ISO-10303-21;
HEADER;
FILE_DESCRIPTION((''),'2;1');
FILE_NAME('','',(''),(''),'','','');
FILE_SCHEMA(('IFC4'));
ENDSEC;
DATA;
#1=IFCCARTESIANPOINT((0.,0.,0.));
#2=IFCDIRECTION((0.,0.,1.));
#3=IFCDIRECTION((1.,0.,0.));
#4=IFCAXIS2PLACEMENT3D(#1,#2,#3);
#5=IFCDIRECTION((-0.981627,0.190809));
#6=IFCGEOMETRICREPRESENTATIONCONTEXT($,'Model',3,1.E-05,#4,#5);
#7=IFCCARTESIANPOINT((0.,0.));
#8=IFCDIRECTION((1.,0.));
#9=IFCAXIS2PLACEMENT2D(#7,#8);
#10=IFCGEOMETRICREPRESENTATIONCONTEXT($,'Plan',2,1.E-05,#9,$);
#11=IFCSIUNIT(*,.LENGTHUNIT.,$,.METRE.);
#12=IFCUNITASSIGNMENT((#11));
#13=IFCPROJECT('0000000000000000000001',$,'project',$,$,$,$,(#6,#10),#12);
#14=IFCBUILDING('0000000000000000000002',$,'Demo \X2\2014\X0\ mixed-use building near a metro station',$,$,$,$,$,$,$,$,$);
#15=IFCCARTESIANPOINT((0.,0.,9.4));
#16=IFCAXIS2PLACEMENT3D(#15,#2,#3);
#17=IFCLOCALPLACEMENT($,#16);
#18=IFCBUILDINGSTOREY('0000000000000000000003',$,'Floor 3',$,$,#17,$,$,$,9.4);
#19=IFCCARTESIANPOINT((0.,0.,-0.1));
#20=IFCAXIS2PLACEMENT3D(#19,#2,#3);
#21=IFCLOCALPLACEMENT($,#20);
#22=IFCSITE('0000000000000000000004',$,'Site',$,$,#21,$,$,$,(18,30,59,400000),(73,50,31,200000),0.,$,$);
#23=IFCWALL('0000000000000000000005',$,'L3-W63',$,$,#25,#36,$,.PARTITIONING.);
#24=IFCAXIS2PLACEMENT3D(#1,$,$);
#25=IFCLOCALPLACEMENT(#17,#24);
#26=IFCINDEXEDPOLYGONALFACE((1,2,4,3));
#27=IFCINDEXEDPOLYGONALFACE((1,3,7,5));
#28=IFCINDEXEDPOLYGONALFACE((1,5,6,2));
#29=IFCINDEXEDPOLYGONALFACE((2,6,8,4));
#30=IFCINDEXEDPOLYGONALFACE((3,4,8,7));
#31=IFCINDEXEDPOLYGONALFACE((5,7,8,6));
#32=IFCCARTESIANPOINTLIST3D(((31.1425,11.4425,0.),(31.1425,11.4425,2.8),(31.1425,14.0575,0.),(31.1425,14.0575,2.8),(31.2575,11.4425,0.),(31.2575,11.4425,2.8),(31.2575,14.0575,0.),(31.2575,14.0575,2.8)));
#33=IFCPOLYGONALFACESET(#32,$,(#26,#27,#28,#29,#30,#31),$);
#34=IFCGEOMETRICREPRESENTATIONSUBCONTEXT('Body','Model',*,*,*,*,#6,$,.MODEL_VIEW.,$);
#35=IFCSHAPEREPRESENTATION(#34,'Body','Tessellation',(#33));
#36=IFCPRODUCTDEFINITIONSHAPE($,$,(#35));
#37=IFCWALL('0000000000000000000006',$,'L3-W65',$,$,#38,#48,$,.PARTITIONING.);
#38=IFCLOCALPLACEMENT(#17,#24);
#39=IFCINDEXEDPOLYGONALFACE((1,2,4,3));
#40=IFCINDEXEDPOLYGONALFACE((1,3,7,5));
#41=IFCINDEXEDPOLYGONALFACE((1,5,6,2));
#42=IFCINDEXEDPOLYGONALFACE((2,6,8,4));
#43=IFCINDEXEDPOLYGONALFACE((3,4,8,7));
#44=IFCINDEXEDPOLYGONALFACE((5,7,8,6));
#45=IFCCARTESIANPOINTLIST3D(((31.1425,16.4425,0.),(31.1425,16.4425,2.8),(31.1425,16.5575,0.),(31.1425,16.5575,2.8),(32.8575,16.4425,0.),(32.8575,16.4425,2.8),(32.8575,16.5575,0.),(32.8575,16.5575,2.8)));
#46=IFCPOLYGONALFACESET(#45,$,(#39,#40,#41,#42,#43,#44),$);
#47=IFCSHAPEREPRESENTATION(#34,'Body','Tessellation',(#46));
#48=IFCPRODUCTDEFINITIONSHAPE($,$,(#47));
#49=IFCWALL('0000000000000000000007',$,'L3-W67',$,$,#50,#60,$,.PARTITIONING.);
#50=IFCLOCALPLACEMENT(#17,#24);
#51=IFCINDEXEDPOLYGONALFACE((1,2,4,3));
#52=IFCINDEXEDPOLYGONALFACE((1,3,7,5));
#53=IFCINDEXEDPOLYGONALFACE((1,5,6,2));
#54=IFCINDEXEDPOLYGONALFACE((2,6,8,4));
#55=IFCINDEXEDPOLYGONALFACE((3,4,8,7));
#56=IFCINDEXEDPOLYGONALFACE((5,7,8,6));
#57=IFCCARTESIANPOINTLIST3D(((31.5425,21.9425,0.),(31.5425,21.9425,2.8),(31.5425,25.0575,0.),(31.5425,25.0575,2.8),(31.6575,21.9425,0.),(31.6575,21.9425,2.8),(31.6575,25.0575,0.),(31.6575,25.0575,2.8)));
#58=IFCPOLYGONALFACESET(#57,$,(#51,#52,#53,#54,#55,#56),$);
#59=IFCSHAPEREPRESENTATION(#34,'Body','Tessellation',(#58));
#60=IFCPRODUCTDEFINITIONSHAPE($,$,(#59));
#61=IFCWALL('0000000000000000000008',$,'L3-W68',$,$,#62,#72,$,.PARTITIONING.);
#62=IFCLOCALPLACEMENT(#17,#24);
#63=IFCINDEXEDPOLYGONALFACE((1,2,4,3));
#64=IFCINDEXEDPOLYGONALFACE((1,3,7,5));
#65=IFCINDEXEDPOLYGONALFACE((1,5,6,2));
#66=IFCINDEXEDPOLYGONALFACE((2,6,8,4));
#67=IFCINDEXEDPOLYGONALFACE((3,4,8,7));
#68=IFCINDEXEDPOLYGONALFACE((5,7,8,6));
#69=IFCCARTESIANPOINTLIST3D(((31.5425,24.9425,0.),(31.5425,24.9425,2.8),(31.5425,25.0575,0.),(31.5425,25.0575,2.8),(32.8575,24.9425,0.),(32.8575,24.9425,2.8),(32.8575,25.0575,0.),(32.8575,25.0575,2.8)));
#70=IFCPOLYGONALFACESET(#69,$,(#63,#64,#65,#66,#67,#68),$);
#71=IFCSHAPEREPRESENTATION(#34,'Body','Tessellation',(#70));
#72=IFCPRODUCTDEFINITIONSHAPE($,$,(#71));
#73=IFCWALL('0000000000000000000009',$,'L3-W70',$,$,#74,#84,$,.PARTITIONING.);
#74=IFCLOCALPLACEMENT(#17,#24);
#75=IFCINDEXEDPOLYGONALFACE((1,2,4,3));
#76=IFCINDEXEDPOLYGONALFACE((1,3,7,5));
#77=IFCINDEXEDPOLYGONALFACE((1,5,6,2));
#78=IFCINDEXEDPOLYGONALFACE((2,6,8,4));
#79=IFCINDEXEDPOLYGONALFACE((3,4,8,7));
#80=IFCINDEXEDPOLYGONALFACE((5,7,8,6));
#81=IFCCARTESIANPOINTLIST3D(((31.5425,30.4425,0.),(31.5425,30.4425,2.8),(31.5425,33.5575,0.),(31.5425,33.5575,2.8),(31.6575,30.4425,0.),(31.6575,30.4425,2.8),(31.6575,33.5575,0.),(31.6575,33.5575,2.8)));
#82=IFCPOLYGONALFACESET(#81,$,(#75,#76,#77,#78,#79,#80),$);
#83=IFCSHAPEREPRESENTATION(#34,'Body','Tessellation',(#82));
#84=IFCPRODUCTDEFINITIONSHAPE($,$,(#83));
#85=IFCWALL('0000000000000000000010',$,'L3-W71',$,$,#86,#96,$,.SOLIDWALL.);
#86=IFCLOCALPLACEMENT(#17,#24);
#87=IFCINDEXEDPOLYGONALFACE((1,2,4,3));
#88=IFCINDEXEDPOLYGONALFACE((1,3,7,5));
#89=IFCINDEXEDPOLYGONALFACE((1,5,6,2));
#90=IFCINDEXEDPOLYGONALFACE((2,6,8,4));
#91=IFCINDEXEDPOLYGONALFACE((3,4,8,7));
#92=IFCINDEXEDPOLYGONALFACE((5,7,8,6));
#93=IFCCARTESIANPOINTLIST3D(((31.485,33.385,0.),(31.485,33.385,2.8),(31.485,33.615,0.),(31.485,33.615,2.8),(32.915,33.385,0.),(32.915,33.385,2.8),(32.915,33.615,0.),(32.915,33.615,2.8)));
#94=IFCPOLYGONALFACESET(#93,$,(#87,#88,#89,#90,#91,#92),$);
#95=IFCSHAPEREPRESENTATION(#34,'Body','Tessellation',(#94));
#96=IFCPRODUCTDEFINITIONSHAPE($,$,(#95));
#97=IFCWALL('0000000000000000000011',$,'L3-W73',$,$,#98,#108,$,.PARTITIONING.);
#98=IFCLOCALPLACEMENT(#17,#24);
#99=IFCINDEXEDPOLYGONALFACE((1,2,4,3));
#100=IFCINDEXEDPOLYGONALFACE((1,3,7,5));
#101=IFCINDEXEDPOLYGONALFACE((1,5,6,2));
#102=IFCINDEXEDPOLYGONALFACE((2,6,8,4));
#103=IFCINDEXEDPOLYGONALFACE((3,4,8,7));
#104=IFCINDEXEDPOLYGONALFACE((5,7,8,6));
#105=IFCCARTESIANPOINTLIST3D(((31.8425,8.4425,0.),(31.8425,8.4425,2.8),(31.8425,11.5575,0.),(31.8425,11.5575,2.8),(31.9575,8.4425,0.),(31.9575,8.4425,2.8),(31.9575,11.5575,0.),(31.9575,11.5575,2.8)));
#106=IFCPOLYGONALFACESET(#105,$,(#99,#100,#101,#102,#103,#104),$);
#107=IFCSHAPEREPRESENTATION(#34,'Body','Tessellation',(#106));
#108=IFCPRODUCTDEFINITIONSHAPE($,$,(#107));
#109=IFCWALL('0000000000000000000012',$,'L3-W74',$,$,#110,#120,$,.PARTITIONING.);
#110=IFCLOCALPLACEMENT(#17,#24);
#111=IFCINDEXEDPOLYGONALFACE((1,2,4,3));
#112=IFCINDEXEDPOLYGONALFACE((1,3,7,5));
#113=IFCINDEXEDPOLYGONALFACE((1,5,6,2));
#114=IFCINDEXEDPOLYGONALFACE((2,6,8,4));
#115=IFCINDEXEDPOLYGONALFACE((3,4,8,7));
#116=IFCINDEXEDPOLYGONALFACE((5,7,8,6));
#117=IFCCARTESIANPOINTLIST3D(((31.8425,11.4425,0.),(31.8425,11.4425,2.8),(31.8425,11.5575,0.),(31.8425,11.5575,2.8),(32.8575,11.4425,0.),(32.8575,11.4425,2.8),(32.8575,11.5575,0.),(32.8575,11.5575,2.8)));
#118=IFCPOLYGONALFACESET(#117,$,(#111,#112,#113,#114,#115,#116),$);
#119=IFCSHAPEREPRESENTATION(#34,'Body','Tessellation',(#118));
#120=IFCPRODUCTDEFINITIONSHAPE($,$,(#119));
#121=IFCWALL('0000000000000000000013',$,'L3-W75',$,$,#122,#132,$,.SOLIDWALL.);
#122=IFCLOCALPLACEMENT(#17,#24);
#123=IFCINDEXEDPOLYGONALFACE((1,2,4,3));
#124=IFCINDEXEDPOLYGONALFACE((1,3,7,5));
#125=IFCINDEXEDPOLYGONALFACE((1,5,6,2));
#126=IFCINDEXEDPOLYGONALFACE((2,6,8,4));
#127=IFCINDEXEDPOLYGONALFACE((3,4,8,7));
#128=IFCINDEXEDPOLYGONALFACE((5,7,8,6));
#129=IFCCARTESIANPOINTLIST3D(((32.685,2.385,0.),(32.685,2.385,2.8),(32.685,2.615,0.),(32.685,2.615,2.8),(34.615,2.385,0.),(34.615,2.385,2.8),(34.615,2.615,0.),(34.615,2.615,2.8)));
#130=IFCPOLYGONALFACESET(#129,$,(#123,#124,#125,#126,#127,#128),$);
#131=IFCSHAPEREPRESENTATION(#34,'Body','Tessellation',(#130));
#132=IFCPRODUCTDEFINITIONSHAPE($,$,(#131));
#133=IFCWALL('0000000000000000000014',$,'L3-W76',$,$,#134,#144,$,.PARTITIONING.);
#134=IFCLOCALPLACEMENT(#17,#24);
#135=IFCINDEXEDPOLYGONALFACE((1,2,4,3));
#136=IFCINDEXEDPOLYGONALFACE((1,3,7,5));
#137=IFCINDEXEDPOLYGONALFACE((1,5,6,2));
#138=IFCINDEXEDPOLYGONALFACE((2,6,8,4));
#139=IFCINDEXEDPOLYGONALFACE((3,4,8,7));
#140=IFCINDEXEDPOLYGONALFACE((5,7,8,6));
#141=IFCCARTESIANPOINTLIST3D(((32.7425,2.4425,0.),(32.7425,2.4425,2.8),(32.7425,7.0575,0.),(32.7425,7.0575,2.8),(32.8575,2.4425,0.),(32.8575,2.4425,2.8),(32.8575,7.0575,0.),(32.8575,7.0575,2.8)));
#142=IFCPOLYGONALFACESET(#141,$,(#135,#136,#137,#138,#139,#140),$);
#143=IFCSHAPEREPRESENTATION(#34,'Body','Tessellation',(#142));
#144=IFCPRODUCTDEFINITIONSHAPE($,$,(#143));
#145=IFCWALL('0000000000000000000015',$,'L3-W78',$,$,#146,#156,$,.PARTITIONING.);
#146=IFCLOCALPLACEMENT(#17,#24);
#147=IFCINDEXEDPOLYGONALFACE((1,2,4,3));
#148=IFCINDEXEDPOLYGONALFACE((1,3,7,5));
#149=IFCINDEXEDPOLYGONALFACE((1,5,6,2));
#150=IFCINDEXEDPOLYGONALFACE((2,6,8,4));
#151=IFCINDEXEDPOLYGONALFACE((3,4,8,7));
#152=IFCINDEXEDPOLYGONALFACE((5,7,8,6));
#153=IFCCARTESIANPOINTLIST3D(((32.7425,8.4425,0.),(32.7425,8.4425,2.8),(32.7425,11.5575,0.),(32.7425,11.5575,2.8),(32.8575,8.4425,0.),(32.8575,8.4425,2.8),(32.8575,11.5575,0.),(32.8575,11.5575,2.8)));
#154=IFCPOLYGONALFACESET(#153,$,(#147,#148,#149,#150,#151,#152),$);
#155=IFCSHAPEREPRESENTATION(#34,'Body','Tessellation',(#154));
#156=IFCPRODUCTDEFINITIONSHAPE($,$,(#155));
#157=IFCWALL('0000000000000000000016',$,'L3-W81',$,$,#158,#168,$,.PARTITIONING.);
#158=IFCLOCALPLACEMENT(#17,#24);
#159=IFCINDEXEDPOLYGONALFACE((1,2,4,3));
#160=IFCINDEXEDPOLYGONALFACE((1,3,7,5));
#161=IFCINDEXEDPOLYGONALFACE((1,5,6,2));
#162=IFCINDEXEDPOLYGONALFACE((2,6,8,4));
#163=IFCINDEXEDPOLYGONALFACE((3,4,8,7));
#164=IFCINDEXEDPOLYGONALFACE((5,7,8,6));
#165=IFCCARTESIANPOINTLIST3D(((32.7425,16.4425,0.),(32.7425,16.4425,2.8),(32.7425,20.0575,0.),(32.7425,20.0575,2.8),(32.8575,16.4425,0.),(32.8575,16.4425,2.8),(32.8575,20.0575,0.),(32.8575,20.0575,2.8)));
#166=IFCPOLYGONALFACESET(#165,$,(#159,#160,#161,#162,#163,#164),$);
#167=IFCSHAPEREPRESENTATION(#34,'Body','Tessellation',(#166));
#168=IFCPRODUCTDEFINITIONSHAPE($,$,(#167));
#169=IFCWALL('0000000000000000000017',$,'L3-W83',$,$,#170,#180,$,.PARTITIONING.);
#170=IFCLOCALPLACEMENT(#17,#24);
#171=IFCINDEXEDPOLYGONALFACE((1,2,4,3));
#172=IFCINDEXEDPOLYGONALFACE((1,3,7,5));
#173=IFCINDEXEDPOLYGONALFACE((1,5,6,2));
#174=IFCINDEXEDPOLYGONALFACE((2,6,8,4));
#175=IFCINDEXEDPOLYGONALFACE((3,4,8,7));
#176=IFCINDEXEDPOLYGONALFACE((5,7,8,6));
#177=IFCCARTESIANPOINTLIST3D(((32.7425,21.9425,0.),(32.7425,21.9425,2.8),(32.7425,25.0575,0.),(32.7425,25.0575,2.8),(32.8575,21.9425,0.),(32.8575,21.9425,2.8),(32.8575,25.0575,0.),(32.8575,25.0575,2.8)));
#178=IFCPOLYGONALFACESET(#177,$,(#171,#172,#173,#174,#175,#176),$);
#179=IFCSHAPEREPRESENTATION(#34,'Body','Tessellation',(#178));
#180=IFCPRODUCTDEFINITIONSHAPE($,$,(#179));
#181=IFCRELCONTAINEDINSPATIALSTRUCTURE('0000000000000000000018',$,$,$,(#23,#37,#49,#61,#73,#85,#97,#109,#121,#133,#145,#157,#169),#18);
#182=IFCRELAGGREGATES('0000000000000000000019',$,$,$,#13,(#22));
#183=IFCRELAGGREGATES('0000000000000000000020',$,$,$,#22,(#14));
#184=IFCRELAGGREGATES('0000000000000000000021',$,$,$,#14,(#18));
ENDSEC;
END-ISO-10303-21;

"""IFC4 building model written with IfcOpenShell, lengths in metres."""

from ifc_helpers import new_model, si_unit, direction, frame, origin_with_axes, origin_2d_with_axis, place, context, subcontext, project, spatial, line, indexed_curve, outline, extrude, element, save


model = new_model("IFC4")

# Units and contexts
model_context = context("Model", 3, precision=1e-05, world=origin_with_axes(), true_north=direction((-0.981627, 0.190809)))
plan_context = context("Plan", 2, precision=1e-05, world=origin_2d_with_axis())
body_context = subcontext(model_context, "Body", "Model", "MODEL_VIEW")
ifc_project = project(units=[si_unit("LENGTHUNIT", "METRE")], contexts=[model_context, plan_context])

# Site, building, storey
site_placement = place(None, frame((0.0, 0.0, -0.1), z_axis=(0.0, 0.0, 1.0), x_axis=(1.0, 0.0, 0.0)))
site = spatial("IfcSite", under=ifc_project, at=site_placement, Name="Site", RefLatitude=(18, 30, 59, 400000), RefLongitude=(73, 50, 31, 200000), RefElevation=0.0)
building = spatial("IfcBuilding", under=site, Name="Demo — mixed-use building near a metro station")
storey_placement = place(None, frame((0.0, 0.0, 9.4), z_axis=(0.0, 0.0, 1.0), x_axis=(1.0, 0.0, 0.0)))
storey = spatial("IfcBuildingStorey", under=building, at=storey_placement, Name="Floor 3", Elevation=9.4)

# Wall
wall_1_placement = place(storey_placement, frame((0.0, 0.0, -9.4), z_axis=(0.0, 0.0, 1.0), x_axis=(1.0, 0.0, 0.0)))
element("IfcWall", 1, at=wall_1_placement, inside=storey, Name="L3-W63", PredefinedType="PARTITIONING", context=body_context, shape_type="SweptSolid", body=[
    extrude(outline(indexed_curve([(31.1425, 11.4425), (31.1425, 14.0575), (31.2575, 14.0575), (31.2575, 11.4425)], segments=[line(1, 2, 3, 4, 1)])), frame((0.0, 0.0, 9.4), z_axis=(0.0, 0.0, 1.0), x_axis=(1.0, 0.0, 0.0)), (0.0, 0.0, 1.0), 2.8),
])

# Wall
wall_2_placement = place(storey_placement, frame((0.0, 0.0, -9.4), z_axis=(0.0, 0.0, 1.0), x_axis=(1.0, 0.0, 0.0)))
element("IfcWall", 2, at=wall_2_placement, inside=storey, Name="L3-W65", PredefinedType="PARTITIONING", context=body_context, shape_type="SweptSolid", body=[
    extrude(outline(indexed_curve([(32.8575, 16.4425), (31.1425, 16.4425), (31.1425, 16.5575), (32.8575, 16.5575)], segments=[line(1, 2, 3, 4, 1)])), frame((0.0, 0.0, 9.4), z_axis=(0.0, 0.0, 1.0), x_axis=(1.0, 0.0, 0.0)), (0.0, 0.0, 1.0), 2.8),
])

# Walls
wall_3_placement = place(storey_placement, frame((0.0, 0.0, -9.4), z_axis=(0.0, 0.0, 1.0), x_axis=(1.0, 0.0, 0.0)))
element("IfcWall", 3, at=wall_3_placement, inside=storey, Name="L3-W67", PredefinedType="PARTITIONING", context=body_context, shape_type="SweptSolid", body=[
    extrude(outline(indexed_curve([(31.5425, 21.9425), (31.5425, 25.0575), (31.6575, 25.0575), (31.6575, 21.9425)], segments=[line(1, 2, 3, 4, 1)])), frame((0.0, 0.0, 9.4), z_axis=(0.0, 0.0, 1.0), x_axis=(1.0, 0.0, 0.0)), (0.0, 0.0, 1.0), 2.8),
])
wall_4_placement = place(storey_placement, frame((0.0, 0.0, -9.4), z_axis=(0.0, 0.0, 1.0), x_axis=(1.0, 0.0, 0.0)))
element("IfcWall", 4, at=wall_4_placement, inside=storey, Name="L3-W68", PredefinedType="PARTITIONING", context=body_context, shape_type="SweptSolid", body=[
    extrude(outline(indexed_curve([(32.8575, 24.9425), (31.5425, 24.9425), (31.5425, 25.0575), (32.8575, 25.0575)], segments=[line(1, 2, 3, 4, 1)])), frame((0.0, 0.0, 9.4), z_axis=(0.0, 0.0, 1.0), x_axis=(1.0, 0.0, 0.0)), (0.0, 0.0, 1.0), 2.8),
])

# Walls
wall_5_placement = place(storey_placement, frame((0.0, 0.0, -9.4), z_axis=(0.0, 0.0, 1.0), x_axis=(1.0, 0.0, 0.0)))
element("IfcWall", 5, at=wall_5_placement, inside=storey, Name="L3-W70", PredefinedType="PARTITIONING", context=body_context, shape_type="SweptSolid", body=[
    extrude(outline(indexed_curve([(31.5425, 30.4425), (31.5425, 33.5575), (31.6575, 33.5575), (31.6575, 30.4425)], segments=[line(1, 2, 3, 4, 1)])), frame((0.0, 0.0, 9.4), z_axis=(0.0, 0.0, 1.0), x_axis=(1.0, 0.0, 0.0)), (0.0, 0.0, 1.0), 2.8),
])
wall_6_placement = place(storey_placement, frame((0.0, 0.0, -9.4), z_axis=(0.0, 0.0, 1.0), x_axis=(1.0, 0.0, 0.0)))
element("IfcWall", 6, at=wall_6_placement, inside=storey, Name="L3-W71", PredefinedType="SOLIDWALL", context=body_context, shape_type="SweptSolid", body=[
    extrude(outline(indexed_curve([(32.915, 33.385), (31.485, 33.385), (31.485, 33.615), (32.915, 33.615)], segments=[line(1, 2, 3, 4, 1)])), frame((0.0, 0.0, 9.4), z_axis=(0.0, 0.0, 1.0), x_axis=(1.0, 0.0, 0.0)), (0.0, 0.0, 1.0), 2.8),
])

# Walls
wall_7_placement = place(storey_placement, frame((0.0, 0.0, -9.4), z_axis=(0.0, 0.0, 1.0), x_axis=(1.0, 0.0, 0.0)))
element("IfcWall", 7, at=wall_7_placement, inside=storey, Name="L3-W73", PredefinedType="PARTITIONING", context=body_context, shape_type="SweptSolid", body=[
    extrude(outline(indexed_curve([(31.8425, 8.4425), (31.8425, 11.5575), (31.9575, 11.5575), (31.9575, 8.4425)], segments=[line(1, 2, 3, 4, 1)])), frame((0.0, 0.0, 9.4), z_axis=(0.0, 0.0, 1.0), x_axis=(1.0, 0.0, 0.0)), (0.0, 0.0, 1.0), 2.8),
])
wall_8_placement = place(storey_placement, frame((0.0, 0.0, -9.4), z_axis=(0.0, 0.0, 1.0), x_axis=(1.0, 0.0, 0.0)))
element("IfcWall", 8, at=wall_8_placement, inside=storey, Name="L3-W74", PredefinedType="PARTITIONING", context=body_context, shape_type="SweptSolid", body=[
    extrude(outline(indexed_curve([(31.8425, 11.5575), (32.8575, 11.5575), (32.8575, 11.4425), (31.8425, 11.4425)], segments=[line(1, 2, 3, 4, 1)])), frame((0.0, 0.0, 9.4), z_axis=(0.0, 0.0, 1.0), x_axis=(1.0, 0.0, 0.0)), (0.0, 0.0, 1.0), 2.8),
])
wall_9_placement = place(storey_placement, frame((0.0, 0.0, -9.4), z_axis=(0.0, 0.0, 1.0), x_axis=(1.0, 0.0, 0.0)))
element("IfcWall", 9, at=wall_9_placement, inside=storey, Name="L3-W75", PredefinedType="SOLIDWALL", context=body_context, shape_type="SweptSolid", body=[
    extrude(outline(indexed_curve([(32.685, 2.615), (34.615, 2.615), (34.615, 2.385), (32.685, 2.385)], segments=[line(1, 2, 3, 4, 1)])), frame((0.0, 0.0, 9.4), z_axis=(0.0, 0.0, 1.0), x_axis=(1.0, 0.0, 0.0)), (0.0, 0.0, 1.0), 2.8),
])
wall_10_placement = place(storey_placement, frame((0.0, 0.0, -9.4), z_axis=(0.0, 0.0, 1.0), x_axis=(1.0, 0.0, 0.0)))
element("IfcWall", 10, at=wall_10_placement, inside=storey, Name="L3-W76", PredefinedType="PARTITIONING", context=body_context, shape_type="SweptSolid", body=[
    extrude(outline(indexed_curve([(32.8575, 7.0575), (32.8575, 2.4425), (32.7425, 2.4425), (32.7425, 7.0575)], segments=[line(1, 2, 3, 4, 1)])), frame((0.0, 0.0, 9.4), z_axis=(0.0, 0.0, 1.0), x_axis=(1.0, 0.0, 0.0)), (0.0, 0.0, 1.0), 2.8),
])

# Wall
wall_11_placement = place(storey_placement, frame((0.0, 0.0, -9.4), z_axis=(0.0, 0.0, 1.0), x_axis=(1.0, 0.0, 0.0)))
element("IfcWall", 11, at=wall_11_placement, inside=storey, Name="L3-W78", PredefinedType="PARTITIONING", context=body_context, shape_type="SweptSolid", body=[
    extrude(outline(indexed_curve([(32.8575, 11.5575), (32.8575, 8.4425), (32.7425, 8.4425), (32.7425, 11.5575)], segments=[line(1, 2, 3, 4, 1)])), frame((0.0, 0.0, 9.4), z_axis=(0.0, 0.0, 1.0), x_axis=(1.0, 0.0, 0.0)), (0.0, 0.0, 1.0), 2.8),
])

# Wall
wall_12_placement = place(storey_placement, frame((0.0, 0.0, -9.4), z_axis=(0.0, 0.0, 1.0), x_axis=(1.0, 0.0, 0.0)))
element("IfcWall", 12, at=wall_12_placement, inside=storey, Name="L3-W81", PredefinedType="PARTITIONING", context=body_context, shape_type="SweptSolid", body=[
    extrude(outline(indexed_curve([(32.8575, 20.0575), (32.8575, 16.4425), (32.7425, 16.4425), (32.7425, 20.0575)], segments=[line(1, 2, 3, 4, 1)])), frame((0.0, 0.0, 9.4), z_axis=(0.0, 0.0, 1.0), x_axis=(1.0, 0.0, 0.0)), (0.0, 0.0, 1.0), 2.8),
])

# Wall
wall_13_placement = place(storey_placement, frame((0.0, 0.0, -9.4), z_axis=(0.0, 0.0, 1.0), x_axis=(1.0, 0.0, 0.0)))
element("IfcWall", 13, at=wall_13_placement, inside=storey, Name="L3-W83", PredefinedType="PARTITIONING", context=body_context, shape_type="SweptSolid", body=[
    extrude(outline(indexed_curve([(32.8575, 25.0575), (32.8575, 21.9425), (32.7425, 21.9425), (32.7425, 25.0575)], segments=[line(1, 2, 3, 4, 1)])), frame((0.0, 0.0, 9.4), z_axis=(0.0, 0.0, 1.0), x_axis=(1.0, 0.0, 0.0)), (0.0, 0.0, 1.0), 2.8),
])

save(model, "model.ifc")
